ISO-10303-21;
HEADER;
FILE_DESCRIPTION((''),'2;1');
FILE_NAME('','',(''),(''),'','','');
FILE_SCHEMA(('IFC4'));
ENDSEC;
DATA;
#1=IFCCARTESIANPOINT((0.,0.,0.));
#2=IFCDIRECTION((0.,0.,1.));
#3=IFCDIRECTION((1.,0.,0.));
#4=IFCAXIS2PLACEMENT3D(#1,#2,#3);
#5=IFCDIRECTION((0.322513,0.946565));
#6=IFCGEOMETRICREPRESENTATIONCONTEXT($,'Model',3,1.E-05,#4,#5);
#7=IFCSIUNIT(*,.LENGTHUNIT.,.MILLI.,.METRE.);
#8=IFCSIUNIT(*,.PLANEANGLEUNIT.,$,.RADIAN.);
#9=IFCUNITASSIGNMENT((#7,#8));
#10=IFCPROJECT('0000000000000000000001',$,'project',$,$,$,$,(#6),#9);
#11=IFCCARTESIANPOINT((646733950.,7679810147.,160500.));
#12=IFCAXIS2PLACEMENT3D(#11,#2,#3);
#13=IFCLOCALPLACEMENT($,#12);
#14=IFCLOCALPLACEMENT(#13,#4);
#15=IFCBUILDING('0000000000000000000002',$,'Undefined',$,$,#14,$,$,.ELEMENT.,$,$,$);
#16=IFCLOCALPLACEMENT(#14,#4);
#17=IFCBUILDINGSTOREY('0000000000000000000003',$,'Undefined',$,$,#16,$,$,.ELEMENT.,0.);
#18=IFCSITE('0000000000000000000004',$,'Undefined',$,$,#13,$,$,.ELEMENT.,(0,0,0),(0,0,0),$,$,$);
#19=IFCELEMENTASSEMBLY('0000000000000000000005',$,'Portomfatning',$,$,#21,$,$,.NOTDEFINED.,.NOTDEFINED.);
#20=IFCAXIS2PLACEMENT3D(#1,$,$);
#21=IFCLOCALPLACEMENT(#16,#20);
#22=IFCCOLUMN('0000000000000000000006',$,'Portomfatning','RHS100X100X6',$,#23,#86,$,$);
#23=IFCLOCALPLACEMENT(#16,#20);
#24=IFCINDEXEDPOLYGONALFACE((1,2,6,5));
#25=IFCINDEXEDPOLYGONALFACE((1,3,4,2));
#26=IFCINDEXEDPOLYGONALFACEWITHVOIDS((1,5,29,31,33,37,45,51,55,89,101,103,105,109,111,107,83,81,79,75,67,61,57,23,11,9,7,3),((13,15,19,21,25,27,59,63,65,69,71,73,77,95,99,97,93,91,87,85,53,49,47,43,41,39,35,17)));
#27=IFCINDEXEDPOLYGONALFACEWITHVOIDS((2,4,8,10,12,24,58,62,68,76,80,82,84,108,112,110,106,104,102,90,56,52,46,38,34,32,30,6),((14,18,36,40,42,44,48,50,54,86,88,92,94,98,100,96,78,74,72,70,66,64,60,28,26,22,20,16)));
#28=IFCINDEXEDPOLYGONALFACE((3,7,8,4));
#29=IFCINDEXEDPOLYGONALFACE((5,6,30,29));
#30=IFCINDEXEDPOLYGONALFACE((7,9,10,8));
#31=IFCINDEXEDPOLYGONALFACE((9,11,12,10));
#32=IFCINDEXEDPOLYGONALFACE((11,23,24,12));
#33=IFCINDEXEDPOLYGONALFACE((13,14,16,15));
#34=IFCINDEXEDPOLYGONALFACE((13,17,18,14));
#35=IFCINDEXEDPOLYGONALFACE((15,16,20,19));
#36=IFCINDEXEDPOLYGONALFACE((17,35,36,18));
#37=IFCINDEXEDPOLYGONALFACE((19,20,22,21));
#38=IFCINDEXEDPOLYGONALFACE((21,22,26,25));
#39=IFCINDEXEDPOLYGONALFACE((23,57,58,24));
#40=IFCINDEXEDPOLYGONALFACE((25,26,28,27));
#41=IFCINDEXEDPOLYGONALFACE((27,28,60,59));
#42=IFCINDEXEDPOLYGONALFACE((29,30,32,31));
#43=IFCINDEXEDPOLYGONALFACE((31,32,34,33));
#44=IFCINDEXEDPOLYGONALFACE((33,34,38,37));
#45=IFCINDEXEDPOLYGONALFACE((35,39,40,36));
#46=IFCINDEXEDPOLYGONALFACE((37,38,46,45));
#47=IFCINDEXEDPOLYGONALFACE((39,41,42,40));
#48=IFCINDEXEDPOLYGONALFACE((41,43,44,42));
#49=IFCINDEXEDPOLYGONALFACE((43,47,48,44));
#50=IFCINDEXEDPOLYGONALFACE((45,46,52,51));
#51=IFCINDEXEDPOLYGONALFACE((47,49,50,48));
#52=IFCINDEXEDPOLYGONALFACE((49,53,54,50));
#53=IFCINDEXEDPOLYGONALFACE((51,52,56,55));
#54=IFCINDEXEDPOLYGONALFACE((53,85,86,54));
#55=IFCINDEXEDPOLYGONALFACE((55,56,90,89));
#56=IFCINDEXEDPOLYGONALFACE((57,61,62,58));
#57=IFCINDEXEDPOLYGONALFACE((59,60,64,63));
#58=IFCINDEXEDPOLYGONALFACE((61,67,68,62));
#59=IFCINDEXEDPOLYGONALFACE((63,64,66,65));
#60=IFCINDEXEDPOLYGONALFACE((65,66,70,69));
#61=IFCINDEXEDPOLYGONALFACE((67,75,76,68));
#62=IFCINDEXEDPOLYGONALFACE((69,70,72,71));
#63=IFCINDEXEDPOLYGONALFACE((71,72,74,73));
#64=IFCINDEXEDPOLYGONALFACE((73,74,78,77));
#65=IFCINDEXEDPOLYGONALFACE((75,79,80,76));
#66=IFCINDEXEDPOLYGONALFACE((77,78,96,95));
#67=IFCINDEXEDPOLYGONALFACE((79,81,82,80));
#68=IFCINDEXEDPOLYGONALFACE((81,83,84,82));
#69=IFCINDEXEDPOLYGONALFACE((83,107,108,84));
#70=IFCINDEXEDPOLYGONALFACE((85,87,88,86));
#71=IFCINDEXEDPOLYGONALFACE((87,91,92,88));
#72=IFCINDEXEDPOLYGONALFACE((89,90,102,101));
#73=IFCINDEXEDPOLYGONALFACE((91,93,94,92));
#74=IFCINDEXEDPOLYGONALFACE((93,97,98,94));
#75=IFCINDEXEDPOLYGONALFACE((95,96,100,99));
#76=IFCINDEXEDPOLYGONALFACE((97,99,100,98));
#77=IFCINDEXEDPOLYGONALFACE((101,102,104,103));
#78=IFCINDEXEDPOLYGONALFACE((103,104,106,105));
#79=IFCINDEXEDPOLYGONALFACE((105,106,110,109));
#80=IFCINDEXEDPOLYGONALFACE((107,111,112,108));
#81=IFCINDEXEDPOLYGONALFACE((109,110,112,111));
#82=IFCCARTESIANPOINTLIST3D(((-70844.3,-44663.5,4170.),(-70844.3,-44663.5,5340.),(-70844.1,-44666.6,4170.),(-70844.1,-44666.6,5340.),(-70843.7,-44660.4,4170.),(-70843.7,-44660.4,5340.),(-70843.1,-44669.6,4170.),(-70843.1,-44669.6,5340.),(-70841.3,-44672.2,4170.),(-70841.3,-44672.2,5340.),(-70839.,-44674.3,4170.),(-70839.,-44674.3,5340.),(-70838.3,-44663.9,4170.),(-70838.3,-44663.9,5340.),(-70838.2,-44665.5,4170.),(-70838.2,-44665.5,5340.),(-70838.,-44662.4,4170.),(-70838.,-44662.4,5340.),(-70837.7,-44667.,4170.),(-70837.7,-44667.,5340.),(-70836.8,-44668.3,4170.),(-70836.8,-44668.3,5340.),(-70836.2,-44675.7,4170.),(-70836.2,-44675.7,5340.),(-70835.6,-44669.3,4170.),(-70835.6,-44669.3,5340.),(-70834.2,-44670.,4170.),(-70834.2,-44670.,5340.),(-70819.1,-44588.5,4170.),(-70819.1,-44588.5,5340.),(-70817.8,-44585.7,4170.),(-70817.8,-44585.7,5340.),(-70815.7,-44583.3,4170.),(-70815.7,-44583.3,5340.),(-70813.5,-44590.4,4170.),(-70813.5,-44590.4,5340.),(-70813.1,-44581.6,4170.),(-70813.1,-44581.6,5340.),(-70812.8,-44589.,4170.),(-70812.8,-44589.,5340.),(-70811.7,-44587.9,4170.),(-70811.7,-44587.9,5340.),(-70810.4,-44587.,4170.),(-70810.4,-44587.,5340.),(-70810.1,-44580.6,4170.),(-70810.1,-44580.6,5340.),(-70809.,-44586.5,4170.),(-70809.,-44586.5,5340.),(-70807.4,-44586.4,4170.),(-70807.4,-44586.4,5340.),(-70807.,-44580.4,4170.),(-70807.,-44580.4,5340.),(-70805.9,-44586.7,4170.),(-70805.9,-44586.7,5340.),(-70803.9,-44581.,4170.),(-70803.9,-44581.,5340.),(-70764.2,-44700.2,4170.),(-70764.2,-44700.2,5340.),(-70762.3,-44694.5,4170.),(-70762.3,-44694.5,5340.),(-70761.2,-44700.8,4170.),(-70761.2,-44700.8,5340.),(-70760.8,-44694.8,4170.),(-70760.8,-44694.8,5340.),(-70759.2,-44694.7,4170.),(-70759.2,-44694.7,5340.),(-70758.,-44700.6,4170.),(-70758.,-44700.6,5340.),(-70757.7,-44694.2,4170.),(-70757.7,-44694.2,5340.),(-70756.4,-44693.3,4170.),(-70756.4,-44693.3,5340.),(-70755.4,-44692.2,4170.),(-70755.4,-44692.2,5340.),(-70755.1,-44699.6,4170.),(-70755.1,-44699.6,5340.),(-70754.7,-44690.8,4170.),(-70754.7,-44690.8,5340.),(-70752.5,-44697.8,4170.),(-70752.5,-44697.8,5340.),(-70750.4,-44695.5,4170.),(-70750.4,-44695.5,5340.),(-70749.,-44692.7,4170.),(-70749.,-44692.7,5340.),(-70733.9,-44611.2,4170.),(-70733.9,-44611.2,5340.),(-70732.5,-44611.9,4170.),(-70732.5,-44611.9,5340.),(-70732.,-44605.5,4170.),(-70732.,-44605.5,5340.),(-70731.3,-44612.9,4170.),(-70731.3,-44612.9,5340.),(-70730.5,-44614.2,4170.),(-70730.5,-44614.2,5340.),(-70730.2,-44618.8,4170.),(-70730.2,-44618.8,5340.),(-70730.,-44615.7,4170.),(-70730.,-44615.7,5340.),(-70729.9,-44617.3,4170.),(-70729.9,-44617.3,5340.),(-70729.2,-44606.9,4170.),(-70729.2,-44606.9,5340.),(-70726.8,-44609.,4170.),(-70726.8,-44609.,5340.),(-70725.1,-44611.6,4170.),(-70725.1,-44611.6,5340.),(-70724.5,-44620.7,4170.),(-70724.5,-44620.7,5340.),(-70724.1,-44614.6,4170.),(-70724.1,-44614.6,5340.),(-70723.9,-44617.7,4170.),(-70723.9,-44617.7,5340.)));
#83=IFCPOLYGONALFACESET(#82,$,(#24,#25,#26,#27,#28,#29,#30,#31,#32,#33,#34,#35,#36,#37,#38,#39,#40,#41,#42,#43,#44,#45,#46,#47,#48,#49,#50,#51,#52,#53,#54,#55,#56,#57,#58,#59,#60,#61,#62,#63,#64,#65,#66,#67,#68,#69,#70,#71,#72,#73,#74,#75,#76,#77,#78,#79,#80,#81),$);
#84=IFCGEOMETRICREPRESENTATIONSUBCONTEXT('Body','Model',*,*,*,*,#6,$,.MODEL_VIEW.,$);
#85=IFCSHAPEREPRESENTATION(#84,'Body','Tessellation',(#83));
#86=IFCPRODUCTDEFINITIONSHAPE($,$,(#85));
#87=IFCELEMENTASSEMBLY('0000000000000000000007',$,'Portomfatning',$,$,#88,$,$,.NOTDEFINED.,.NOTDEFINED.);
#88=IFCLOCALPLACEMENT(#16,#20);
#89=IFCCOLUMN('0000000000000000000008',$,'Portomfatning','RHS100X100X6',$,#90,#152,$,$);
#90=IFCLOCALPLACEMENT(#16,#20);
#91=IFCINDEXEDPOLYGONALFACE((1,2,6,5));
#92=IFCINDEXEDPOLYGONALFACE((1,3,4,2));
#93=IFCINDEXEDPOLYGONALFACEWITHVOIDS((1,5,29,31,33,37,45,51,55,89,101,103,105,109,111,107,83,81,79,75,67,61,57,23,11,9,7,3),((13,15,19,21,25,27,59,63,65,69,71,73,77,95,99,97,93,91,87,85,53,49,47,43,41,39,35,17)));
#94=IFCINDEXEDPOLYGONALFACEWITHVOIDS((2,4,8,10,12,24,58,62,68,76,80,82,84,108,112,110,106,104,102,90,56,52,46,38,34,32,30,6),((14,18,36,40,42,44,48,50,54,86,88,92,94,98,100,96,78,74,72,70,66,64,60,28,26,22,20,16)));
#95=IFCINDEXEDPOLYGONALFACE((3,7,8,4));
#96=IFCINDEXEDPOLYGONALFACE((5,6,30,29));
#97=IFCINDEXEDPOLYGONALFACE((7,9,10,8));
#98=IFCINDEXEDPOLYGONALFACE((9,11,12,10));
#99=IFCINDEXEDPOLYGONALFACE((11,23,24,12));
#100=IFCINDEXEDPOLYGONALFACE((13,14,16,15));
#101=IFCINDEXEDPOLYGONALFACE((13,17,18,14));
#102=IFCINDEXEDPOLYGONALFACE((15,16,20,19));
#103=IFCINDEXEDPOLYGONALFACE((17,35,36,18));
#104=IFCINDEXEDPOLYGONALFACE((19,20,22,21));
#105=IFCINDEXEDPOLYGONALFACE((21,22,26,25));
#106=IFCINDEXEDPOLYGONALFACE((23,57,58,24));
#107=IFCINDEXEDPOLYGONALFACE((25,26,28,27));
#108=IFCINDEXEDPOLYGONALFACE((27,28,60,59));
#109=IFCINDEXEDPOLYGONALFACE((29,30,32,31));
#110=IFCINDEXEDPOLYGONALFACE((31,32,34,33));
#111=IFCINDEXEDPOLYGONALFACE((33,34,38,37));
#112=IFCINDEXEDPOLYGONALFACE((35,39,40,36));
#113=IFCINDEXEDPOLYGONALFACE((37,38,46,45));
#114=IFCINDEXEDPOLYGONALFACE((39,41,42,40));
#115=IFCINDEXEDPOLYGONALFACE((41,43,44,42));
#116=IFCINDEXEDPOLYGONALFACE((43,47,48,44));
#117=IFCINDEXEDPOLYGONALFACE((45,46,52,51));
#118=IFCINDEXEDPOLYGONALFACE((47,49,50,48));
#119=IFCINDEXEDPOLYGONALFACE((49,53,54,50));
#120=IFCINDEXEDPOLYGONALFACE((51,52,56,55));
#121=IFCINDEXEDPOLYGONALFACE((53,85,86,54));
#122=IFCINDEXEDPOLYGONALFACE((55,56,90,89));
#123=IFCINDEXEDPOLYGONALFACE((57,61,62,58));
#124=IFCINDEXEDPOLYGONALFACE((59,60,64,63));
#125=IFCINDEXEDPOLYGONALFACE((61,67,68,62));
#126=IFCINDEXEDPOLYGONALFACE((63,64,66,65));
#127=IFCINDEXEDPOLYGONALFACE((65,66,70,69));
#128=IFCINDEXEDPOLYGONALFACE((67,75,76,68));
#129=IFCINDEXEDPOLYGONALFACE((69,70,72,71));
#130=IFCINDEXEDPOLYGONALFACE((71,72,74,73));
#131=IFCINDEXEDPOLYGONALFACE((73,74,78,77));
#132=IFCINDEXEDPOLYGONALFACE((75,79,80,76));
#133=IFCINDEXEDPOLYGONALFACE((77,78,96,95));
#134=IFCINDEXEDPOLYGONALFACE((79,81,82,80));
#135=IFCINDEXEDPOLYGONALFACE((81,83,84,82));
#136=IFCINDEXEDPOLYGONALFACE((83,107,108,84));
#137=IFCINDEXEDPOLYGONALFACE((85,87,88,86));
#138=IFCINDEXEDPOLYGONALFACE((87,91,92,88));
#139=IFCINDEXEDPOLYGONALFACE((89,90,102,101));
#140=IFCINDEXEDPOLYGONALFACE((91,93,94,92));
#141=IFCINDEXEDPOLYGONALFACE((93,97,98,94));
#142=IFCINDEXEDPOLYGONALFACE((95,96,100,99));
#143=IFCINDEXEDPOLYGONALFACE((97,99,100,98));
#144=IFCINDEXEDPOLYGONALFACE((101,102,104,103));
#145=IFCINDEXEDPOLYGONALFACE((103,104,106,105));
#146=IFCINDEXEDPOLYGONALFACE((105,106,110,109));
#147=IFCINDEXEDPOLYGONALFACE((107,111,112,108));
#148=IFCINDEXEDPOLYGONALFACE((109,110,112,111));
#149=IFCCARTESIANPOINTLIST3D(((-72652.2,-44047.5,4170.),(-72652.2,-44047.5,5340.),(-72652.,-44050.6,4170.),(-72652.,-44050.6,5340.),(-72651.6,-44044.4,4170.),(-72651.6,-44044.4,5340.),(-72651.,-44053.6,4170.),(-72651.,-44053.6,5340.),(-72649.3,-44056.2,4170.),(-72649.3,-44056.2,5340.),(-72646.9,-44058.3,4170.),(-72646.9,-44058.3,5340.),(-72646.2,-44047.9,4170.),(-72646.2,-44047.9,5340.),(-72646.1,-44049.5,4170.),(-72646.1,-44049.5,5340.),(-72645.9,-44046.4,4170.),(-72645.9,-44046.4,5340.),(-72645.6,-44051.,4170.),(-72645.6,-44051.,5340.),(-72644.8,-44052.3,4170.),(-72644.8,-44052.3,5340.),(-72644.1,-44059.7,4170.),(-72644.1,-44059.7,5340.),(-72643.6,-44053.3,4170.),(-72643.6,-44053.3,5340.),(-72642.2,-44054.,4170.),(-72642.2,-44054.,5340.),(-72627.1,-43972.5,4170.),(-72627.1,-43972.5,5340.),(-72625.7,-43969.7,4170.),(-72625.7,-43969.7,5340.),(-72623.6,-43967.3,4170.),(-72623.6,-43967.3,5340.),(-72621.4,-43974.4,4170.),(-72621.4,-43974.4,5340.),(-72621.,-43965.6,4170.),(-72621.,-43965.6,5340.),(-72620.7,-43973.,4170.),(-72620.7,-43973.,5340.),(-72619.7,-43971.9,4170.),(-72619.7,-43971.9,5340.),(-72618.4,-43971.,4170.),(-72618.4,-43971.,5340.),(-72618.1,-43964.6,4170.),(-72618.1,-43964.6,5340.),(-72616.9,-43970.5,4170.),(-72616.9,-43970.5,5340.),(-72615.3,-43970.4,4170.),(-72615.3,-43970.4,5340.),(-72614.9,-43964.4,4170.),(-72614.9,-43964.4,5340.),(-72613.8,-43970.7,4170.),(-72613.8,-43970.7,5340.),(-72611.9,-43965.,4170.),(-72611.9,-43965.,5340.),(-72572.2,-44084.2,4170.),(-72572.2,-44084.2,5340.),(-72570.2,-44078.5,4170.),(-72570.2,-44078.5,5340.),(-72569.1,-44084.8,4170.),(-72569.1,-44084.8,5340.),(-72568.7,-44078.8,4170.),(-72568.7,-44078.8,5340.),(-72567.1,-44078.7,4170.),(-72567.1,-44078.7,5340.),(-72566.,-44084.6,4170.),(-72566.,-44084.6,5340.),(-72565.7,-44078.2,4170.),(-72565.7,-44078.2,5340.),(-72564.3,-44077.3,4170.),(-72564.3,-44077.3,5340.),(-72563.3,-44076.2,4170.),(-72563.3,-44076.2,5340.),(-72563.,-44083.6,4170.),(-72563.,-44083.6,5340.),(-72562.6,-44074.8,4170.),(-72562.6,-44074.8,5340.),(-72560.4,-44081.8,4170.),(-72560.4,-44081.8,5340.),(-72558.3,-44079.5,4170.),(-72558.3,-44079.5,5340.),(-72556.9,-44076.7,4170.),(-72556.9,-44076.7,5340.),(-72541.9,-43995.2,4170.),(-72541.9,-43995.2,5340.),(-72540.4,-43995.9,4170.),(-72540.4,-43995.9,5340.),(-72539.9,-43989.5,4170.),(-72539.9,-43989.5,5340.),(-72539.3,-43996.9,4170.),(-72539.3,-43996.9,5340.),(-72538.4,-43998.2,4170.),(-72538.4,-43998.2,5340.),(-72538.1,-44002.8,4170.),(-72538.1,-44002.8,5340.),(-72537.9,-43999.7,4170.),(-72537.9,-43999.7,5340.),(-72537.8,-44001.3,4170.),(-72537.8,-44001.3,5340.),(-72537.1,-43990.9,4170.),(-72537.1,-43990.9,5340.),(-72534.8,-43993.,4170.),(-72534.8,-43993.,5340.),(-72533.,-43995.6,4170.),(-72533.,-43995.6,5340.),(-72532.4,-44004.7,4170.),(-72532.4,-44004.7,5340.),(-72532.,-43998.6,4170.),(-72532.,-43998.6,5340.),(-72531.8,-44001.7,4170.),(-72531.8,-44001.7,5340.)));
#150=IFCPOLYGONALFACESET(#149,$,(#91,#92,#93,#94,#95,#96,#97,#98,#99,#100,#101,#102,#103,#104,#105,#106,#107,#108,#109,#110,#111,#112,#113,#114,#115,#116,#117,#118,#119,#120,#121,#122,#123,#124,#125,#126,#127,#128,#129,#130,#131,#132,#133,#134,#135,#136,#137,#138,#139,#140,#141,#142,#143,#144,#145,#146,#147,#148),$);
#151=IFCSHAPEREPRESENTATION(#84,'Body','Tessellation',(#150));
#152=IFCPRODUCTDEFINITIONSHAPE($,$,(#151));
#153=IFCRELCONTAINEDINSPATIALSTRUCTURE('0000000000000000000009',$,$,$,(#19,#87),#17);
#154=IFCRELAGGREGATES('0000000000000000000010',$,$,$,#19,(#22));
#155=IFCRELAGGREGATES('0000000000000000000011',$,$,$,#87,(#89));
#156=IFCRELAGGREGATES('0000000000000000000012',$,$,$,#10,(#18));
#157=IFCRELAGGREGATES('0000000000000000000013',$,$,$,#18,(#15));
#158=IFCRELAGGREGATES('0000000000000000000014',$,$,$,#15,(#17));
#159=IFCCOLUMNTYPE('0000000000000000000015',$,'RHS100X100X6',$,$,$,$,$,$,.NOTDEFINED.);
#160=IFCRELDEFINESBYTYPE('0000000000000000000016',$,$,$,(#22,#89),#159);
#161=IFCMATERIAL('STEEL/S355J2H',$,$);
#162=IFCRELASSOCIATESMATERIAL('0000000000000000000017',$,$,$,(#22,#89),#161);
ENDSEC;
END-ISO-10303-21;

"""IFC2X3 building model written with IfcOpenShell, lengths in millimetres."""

from ifc_helpers import new_model, si_unit, direction, frame, origin_with_axes, origin_2d_with_axis, place, context, subcontext, project, spatial, hollow_rectangle, extrude, clip, halfspace, material, type_object, element, aggregate, save


model = new_model("IFC2X3")

# Units and contexts
model_context = context("Model", 3, precision=1e-05, world=origin_with_axes(), true_north=direction((0.322513, 0.946565)))
body_context = subcontext(model_context, "Body", "Model", "MODEL_VIEW")
ifc_project = project(units=[si_unit("LENGTHUNIT", "METRE", prefix="MILLI"), si_unit("PLANEANGLEUNIT", "RADIAN")], contexts=[model_context])

# Site, building, storey
site_placement = place(None, frame((646733950.0, 7679810147.0, 160500.0), z_axis=(0.0, 0.0, 1.0), x_axis=(1.0, 0.0, 0.0)))
site = spatial("IfcSite", under=ifc_project, at=site_placement, Name="Undefined", CompositionType="ELEMENT", RefLatitude=(0, 0, 0), RefLongitude=(0, 0, 0))
building_placement = place(site_placement, origin_with_axes())
building = spatial("IfcBuilding", under=site, at=building_placement, Name="Undefined", CompositionType="ELEMENT")
storey_placement = place(building_placement, origin_with_axes())
storey = spatial("IfcBuildingStorey", under=building, at=storey_placement, Name="Undefined", CompositionType="ELEMENT", Elevation=0.0)

# Element assemblies, columns
assembly_1_placement = place(storey_placement, origin_with_axes())
assembly_1 = element("IfcElementAssembly", 1, at=assembly_1_placement, inside=storey, Name="Portomfatning", AssemblyPlace="NOTDEFINED", PredefinedType="NOTDEFINED")
ifc_material_1 = material(Name="STEEL/S355J2H")
column_type = type_object("IfcColumnType", Name="RHS100X100X6", PredefinedType="NOTDEFINED")
column_1_placement = place(assembly_1_placement, frame((-70784.1, -44640.6, 4160.0), z_axis=(0.0, 0.0, 1.0), x_axis=(-0.322513, -0.946565, 0.0)))
column_1 = element("IfcColumn", 2, at=column_1_placement, type_object=column_type, material=ifc_material_1, Name="Portomfatning", Description="RHS100X100X6", context=body_context, shape_type="Clipping", body=[
    clip(clip(extrude(hollow_rectangle(XDim=100.0, YDim=100.0, WallThickness=6.0, InnerFilletRadius=6.0, OuterFilletRadius=12.0, at=origin_2d_with_axis()), frame((0.0, 0.0, 1190.0), z_axis=(0.0, 0.0, -1.0), x_axis=(0.0, 1.0, 0.0)), (0.0, 0.0, 1.0), 1190.0), halfspace(frame((0.0, -50.0, 1180.0), z_axis=(0.0, 0.0, -1.0), x_axis=(1.0, 0.0, 0.0)), True)), halfspace(frame((0.0, -50.0, 10.0), z_axis=(0.0, 0.0, 1.0), x_axis=(-1.0, 0.0, 0.0)), True)),
])
assembly_2_placement = place(storey_placement, origin_with_axes())
assembly_2 = element("IfcElementAssembly", 3, at=assembly_2_placement, inside=storey, Name="Portomfatning", AssemblyPlace="NOTDEFINED", PredefinedType="NOTDEFINED")
column_2_placement = place(assembly_2_placement, frame((-72592.0, -44024.6, 4160.0), z_axis=(0.0, 0.0, 1.0), x_axis=(-0.322513, -0.946565, 0.0)))
column_2 = element("IfcColumn", 4, at=column_2_placement, type_object=column_type, material=ifc_material_1, Name="Portomfatning", Description="RHS100X100X6", context=body_context, shape_type="Clipping", body=[
    clip(clip(extrude(hollow_rectangle(XDim=100.0, YDim=100.0, WallThickness=6.0, InnerFilletRadius=6.0, OuterFilletRadius=12.0, at=origin_2d_with_axis()), frame((0.0, 0.0, 1190.0), z_axis=(0.0, 0.0, -1.0), x_axis=(0.0, 1.0, 0.0)), (0.0, 0.0, 1.0), 1190.0), halfspace(frame((0.0, 50.0, 1180.0), z_axis=(0.0, 0.0, -1.0), x_axis=(-1.0, 0.0, 0.0)), True)), halfspace(frame((0.0, 50.0, 10.0), z_axis=(0.0, 0.0, 1.0), x_axis=(1.0, 0.0, 0.0)), True)),
])

aggregate(assembly_1, [column_1])
aggregate(assembly_2, [column_2])

save(model, "model.ifc")
